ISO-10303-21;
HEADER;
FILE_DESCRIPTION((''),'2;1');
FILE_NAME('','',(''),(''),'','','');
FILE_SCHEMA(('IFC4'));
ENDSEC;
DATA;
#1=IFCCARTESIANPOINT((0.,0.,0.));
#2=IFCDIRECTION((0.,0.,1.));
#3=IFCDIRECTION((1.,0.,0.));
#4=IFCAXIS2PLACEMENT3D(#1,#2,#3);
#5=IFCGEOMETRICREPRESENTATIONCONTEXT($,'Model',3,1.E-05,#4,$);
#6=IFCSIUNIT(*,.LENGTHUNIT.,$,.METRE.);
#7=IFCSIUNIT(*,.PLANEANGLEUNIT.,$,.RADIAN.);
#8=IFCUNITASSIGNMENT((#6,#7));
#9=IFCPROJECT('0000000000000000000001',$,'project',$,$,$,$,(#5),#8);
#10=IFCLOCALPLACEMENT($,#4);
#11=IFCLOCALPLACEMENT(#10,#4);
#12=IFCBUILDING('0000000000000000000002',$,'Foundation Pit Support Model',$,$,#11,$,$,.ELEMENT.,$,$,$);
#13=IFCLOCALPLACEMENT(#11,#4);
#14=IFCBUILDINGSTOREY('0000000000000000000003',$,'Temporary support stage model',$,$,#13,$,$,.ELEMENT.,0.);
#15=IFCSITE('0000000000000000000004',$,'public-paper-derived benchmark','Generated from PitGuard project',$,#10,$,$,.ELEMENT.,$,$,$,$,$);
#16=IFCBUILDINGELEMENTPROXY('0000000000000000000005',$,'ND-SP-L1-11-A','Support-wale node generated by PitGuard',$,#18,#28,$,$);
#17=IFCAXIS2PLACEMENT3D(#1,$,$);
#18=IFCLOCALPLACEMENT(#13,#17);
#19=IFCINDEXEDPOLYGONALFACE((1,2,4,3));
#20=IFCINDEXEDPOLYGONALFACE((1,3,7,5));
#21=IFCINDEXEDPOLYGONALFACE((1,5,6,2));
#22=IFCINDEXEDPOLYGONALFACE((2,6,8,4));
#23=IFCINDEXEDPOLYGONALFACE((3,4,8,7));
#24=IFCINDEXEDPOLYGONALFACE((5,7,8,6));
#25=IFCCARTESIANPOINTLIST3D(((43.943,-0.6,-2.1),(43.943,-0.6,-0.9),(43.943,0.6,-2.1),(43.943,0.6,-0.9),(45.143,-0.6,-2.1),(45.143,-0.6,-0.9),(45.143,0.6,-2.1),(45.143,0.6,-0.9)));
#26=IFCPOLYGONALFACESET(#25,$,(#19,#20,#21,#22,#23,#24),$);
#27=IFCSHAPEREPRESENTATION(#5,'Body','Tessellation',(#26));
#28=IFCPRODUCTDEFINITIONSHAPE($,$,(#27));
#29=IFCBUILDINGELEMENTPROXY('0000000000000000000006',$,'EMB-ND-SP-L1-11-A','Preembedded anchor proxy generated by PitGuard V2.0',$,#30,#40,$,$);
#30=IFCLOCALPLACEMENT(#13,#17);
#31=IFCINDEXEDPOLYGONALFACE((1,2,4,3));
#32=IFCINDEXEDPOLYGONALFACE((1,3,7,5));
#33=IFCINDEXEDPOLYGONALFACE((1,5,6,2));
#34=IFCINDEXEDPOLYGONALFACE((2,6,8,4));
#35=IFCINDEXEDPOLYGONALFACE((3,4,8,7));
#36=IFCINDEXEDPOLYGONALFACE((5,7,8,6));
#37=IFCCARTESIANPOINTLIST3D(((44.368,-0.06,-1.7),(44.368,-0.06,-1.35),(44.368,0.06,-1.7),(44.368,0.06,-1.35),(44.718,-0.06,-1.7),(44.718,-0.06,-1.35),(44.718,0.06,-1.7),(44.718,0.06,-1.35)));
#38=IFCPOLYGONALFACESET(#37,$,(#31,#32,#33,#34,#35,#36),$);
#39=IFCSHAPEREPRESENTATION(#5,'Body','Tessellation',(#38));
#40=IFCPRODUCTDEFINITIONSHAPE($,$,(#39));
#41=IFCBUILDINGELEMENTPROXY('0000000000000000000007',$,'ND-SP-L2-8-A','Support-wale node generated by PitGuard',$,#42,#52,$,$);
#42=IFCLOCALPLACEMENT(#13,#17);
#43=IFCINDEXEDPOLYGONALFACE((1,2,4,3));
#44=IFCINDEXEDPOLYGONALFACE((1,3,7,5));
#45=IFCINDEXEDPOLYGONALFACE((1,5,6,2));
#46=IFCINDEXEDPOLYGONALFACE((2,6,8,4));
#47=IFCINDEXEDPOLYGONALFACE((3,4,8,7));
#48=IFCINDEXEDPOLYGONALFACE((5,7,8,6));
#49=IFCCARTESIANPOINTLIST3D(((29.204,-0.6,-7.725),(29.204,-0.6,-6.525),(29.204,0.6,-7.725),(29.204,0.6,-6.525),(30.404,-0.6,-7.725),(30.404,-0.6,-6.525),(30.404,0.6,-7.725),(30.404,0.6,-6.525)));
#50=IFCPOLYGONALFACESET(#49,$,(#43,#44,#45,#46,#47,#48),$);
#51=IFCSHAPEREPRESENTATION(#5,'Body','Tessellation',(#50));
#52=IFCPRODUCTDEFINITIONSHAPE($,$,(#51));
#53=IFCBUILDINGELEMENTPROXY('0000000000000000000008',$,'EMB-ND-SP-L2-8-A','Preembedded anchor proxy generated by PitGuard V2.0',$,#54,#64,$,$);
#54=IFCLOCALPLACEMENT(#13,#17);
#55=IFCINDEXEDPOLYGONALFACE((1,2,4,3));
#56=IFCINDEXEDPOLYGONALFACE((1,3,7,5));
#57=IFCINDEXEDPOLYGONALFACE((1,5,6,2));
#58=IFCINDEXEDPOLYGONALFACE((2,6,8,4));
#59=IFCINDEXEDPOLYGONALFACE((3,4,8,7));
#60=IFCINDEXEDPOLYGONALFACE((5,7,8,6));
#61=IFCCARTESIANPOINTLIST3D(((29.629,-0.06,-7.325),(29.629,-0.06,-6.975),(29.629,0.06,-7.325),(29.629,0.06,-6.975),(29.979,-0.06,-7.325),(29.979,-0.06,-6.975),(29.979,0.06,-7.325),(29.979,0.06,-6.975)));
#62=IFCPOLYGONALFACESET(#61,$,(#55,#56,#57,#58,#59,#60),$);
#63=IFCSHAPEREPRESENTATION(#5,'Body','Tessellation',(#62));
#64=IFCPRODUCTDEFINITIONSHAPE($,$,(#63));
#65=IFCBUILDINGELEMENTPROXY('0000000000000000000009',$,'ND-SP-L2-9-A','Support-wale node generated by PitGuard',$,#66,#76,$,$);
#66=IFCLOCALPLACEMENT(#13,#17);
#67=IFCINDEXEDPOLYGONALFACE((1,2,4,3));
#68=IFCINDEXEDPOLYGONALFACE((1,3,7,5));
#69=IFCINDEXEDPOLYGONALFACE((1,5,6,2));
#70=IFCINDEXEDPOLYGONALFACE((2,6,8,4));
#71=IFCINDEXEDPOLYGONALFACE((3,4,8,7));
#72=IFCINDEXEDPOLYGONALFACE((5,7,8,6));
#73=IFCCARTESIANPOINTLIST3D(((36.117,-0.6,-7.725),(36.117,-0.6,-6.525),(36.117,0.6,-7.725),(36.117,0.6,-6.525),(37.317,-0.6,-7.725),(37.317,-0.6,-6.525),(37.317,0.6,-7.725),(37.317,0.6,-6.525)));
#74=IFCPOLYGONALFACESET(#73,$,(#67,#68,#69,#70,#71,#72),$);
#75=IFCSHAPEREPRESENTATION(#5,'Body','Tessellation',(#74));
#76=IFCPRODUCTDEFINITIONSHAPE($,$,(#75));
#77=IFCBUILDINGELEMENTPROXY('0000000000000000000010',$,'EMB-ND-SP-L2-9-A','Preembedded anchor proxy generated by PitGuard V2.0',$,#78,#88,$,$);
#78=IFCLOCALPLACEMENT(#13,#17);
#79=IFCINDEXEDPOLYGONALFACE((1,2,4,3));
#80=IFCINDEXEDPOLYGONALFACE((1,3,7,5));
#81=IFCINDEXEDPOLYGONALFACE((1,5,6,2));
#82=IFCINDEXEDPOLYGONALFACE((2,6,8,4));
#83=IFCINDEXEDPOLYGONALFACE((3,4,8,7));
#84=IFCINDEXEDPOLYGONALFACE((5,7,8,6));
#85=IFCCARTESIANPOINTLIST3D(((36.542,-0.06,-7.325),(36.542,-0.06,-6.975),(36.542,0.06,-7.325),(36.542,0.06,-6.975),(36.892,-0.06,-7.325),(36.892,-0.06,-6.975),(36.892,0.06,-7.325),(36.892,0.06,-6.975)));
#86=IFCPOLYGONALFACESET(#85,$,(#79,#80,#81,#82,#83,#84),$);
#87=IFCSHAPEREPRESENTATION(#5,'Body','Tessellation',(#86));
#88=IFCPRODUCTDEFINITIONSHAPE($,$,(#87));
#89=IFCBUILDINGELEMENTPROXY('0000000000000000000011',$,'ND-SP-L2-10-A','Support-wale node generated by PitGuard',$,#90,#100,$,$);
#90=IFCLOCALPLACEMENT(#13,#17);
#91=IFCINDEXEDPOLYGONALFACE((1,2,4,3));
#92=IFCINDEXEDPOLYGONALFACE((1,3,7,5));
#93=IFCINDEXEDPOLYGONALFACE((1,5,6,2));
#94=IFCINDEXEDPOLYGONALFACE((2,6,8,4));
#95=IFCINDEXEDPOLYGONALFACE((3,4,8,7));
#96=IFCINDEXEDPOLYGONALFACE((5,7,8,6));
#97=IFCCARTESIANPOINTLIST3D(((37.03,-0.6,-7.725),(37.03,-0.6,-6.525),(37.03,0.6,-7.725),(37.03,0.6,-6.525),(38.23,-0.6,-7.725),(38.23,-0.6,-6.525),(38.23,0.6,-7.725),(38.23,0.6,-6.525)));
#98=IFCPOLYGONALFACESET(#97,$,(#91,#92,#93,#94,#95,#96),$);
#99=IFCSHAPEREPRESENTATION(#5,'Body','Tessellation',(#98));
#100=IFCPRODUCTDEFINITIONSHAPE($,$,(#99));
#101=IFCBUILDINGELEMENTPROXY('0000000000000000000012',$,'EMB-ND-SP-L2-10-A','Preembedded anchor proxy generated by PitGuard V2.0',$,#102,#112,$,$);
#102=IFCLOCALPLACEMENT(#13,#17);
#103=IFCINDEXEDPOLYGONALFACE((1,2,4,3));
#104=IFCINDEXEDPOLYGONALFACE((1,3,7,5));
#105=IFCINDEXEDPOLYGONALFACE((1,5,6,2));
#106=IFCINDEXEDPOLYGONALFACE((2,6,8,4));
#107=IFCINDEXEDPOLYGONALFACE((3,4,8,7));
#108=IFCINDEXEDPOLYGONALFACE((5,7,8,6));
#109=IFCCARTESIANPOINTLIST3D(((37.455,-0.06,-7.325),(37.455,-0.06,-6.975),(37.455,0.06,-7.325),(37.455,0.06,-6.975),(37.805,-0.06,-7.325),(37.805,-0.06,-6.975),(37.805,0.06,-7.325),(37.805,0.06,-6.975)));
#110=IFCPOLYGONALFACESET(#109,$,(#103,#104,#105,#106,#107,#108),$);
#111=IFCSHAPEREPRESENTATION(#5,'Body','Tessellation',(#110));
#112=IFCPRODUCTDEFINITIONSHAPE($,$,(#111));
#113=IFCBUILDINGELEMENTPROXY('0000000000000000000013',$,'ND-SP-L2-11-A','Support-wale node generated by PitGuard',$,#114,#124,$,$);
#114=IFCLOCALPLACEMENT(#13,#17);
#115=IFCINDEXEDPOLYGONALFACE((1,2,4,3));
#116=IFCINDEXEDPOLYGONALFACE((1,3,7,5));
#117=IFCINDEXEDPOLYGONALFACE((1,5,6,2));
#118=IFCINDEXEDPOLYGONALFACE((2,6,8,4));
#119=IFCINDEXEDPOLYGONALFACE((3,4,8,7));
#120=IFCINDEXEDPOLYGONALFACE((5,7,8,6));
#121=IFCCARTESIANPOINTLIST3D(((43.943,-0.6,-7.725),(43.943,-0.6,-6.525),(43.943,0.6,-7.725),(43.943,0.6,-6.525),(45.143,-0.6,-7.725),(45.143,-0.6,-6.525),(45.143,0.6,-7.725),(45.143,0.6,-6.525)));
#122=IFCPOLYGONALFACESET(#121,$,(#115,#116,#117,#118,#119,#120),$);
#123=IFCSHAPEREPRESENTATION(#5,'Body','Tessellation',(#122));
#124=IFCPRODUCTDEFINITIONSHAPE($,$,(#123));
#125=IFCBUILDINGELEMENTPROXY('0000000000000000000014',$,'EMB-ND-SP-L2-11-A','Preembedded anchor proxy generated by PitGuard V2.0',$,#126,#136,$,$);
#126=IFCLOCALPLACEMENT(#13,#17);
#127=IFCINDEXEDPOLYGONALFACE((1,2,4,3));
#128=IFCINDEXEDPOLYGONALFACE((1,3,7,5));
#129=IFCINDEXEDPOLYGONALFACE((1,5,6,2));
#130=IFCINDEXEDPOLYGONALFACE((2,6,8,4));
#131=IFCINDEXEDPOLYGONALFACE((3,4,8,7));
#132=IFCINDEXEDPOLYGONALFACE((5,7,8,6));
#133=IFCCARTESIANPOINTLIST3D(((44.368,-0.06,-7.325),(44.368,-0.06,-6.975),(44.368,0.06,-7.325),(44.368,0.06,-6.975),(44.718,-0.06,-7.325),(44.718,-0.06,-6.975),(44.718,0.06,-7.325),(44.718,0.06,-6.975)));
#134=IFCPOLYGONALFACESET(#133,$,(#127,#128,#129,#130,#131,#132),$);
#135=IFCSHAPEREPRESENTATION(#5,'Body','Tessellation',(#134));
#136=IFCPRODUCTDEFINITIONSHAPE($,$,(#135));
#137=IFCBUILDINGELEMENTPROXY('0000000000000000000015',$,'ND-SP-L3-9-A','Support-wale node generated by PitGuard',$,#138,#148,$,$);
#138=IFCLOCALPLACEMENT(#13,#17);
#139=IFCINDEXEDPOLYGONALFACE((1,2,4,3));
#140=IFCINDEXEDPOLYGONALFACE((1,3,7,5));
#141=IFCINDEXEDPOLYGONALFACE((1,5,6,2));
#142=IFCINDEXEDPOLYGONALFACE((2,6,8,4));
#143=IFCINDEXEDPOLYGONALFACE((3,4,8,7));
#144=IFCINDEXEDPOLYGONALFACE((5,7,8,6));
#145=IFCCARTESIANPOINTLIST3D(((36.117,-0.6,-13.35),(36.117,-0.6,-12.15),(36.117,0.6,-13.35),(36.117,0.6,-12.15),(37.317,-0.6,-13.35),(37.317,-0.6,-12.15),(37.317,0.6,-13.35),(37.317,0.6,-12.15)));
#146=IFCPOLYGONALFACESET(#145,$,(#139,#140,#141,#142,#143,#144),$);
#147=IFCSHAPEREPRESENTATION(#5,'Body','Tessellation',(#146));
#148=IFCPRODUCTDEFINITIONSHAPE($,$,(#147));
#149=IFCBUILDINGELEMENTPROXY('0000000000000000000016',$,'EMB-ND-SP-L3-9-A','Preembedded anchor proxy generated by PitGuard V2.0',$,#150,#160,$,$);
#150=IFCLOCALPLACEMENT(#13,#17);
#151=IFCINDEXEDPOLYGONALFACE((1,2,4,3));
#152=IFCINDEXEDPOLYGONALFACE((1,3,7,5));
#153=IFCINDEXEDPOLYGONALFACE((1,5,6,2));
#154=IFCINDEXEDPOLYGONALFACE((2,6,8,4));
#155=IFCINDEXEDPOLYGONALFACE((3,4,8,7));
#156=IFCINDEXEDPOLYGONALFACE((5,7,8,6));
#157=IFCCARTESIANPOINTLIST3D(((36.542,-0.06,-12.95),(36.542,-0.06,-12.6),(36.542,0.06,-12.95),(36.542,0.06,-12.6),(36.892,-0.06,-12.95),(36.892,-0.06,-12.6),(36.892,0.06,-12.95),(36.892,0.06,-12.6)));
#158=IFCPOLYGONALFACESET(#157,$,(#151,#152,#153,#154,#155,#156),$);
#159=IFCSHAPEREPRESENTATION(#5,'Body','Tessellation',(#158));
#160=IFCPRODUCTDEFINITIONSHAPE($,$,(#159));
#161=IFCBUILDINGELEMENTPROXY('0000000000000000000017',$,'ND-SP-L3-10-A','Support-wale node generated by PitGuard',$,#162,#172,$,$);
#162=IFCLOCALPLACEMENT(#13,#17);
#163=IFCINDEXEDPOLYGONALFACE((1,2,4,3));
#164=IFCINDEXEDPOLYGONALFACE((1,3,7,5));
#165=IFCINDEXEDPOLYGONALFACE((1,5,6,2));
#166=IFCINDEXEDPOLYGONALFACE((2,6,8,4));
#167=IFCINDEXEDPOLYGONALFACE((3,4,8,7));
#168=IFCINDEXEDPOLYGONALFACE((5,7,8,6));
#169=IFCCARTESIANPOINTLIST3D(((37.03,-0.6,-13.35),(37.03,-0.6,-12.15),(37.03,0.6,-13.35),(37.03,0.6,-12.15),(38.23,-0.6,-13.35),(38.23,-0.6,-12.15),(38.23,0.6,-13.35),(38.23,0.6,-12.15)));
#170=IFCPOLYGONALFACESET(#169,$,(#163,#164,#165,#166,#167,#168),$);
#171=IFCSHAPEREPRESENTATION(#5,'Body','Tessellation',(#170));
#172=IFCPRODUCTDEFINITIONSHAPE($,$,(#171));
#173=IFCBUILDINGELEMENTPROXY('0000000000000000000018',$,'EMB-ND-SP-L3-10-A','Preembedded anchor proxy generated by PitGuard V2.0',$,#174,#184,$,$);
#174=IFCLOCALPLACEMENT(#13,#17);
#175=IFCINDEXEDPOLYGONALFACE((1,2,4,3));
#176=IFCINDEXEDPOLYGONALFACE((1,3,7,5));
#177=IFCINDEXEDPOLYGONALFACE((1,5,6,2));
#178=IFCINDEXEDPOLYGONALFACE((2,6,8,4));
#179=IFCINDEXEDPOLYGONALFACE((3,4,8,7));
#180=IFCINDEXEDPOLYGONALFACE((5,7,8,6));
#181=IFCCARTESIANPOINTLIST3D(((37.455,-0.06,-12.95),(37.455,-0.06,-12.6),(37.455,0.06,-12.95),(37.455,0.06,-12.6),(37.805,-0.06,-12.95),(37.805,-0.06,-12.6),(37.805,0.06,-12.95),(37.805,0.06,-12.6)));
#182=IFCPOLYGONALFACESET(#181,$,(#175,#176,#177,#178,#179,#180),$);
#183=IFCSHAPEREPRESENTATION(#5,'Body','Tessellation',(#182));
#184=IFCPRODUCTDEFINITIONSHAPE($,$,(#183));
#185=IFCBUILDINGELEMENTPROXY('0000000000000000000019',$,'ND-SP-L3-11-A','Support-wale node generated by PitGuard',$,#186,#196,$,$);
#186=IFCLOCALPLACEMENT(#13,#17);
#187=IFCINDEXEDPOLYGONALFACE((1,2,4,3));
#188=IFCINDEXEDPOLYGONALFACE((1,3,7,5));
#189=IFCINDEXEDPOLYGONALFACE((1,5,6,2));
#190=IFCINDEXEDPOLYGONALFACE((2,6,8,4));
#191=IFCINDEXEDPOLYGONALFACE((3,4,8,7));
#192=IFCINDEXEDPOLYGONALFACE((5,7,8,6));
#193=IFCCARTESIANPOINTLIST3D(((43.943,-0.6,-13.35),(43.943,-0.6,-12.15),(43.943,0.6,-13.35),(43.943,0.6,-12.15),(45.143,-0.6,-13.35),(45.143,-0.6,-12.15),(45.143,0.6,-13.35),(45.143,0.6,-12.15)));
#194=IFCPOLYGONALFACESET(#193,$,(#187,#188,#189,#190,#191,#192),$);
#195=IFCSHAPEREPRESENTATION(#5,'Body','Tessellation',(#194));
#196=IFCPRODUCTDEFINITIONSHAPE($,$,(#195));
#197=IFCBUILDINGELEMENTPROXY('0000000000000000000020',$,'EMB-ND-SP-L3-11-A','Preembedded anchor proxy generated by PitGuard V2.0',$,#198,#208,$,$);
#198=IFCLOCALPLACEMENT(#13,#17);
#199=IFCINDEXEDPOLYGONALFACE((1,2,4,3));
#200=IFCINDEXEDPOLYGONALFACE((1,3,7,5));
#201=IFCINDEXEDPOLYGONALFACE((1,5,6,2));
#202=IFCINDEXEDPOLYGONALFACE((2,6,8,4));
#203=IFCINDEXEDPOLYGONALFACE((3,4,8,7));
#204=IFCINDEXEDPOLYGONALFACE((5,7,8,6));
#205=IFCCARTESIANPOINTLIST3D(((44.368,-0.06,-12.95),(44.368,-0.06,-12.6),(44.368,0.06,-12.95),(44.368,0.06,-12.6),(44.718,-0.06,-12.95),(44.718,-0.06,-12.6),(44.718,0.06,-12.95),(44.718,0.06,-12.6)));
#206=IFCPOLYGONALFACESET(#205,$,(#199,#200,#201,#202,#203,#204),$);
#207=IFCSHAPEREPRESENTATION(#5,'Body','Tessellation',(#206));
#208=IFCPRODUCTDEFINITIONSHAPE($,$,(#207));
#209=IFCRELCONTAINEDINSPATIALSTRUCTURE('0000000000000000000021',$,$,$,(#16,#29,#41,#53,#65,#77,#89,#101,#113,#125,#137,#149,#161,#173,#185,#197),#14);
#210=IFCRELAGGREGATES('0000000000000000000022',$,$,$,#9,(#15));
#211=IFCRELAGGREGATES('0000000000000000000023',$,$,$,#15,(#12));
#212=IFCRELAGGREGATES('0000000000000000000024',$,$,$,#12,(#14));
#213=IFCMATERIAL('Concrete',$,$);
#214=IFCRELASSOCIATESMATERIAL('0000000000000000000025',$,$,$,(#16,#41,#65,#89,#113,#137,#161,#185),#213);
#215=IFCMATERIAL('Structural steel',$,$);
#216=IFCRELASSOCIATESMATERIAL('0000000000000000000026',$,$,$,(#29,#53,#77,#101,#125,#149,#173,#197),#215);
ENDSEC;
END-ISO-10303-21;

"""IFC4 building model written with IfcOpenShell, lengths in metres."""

from ifc_helpers import new_model, si_unit, frame, origin_with_axes, origin_2d, place, context, project, spatial, rectangle, extrude, material, element, save


model = new_model("IFC4")

# Units and contexts
model_context = context("Model", 3, precision=1e-05, world=origin_with_axes())
ifc_project = project(units=[si_unit("LENGTHUNIT", "METRE"), si_unit("PLANEANGLEUNIT", "RADIAN")], contexts=[model_context])

# Site, building, storey
site_placement = place(None, origin_with_axes())
site = spatial("IfcSite", under=ifc_project, at=site_placement, Name="public-paper-derived benchmark", Description="Generated from PitGuard project", CompositionType="ELEMENT")
building_placement = place(site_placement, origin_with_axes())
building = spatial("IfcBuilding", under=site, at=building_placement, Name="Foundation Pit Support Model", CompositionType="ELEMENT")
storey_placement = place(building_placement, origin_with_axes())
storey = spatial("IfcBuildingStorey", under=building, at=storey_placement, Name="Temporary support stage model", CompositionType="ELEMENT", Elevation=0.0)

# Shared definitions
ifc_material_1 = material(Name="Concrete")

# Shared definitions
ifc_material_2 = material(Name="Structural steel")

# Building element proxies
proxy_1_placement = place(storey_placement, frame((44.543, 0.0, -2.1), z_axis=(0.0, 0.0, 1.0), x_axis=(1.0, 0.0, 0.0)))
element("IfcBuildingElementProxy", 1, at=proxy_1_placement, inside=storey, material=ifc_material_1, Name="ND-SP-L1-11-A", Description="Support-wale node generated by PitGuard", context=model_context, shape_type="SweptSolid", body=[
    extrude(rectangle(XDim=1.2, YDim=1.2, at=origin_2d()), origin_with_axes(), (0.0, 0.0, 1.0), 1.2),
])
proxy_2_placement = place(storey_placement, frame((44.543, 0.0, -1.7), z_axis=(0.0, 0.0, 1.0), x_axis=(1.0, 0.0, 0.0)))
element("IfcBuildingElementProxy", 2, at=proxy_2_placement, inside=storey, material=ifc_material_2, Name="EMB-ND-SP-L1-11-A", Description="Preembedded anchor proxy generated by PitGuard V2.0", context=model_context, shape_type="SweptSolid", body=[
    extrude(rectangle(XDim=0.35, YDim=0.12, at=origin_2d()), origin_with_axes(), (0.0, 0.0, 1.0), 0.35),
])
proxy_3_placement = place(storey_placement, frame((29.804, 0.0, -7.725), z_axis=(0.0, 0.0, 1.0), x_axis=(1.0, 0.0, 0.0)))
element("IfcBuildingElementProxy", 3, at=proxy_3_placement, inside=storey, material=ifc_material_1, Name="ND-SP-L2-8-A", Description="Support-wale node generated by PitGuard", context=model_context, shape_type="SweptSolid", body=[
    extrude(rectangle(XDim=1.2, YDim=1.2, at=origin_2d()), origin_with_axes(), (0.0, 0.0, 1.0), 1.2),
])
proxy_4_placement = place(storey_placement, frame((29.804, 0.0, -7.325), z_axis=(0.0, 0.0, 1.0), x_axis=(1.0, 0.0, 0.0)))
element("IfcBuildingElementProxy", 4, at=proxy_4_placement, inside=storey, material=ifc_material_2, Name="EMB-ND-SP-L2-8-A", Description="Preembedded anchor proxy generated by PitGuard V2.0", context=model_context, shape_type="SweptSolid", body=[
    extrude(rectangle(XDim=0.35, YDim=0.12, at=origin_2d()), origin_with_axes(), (0.0, 0.0, 1.0), 0.35),
])
proxy_5_placement = place(storey_placement, frame((36.717, 0.0, -7.725), z_axis=(0.0, 0.0, 1.0), x_axis=(1.0, 0.0, 0.0)))
element("IfcBuildingElementProxy", 5, at=proxy_5_placement, inside=storey, material=ifc_material_1, Name="ND-SP-L2-9-A", Description="Support-wale node generated by PitGuard", context=model_context, shape_type="SweptSolid", body=[
    extrude(rectangle(XDim=1.2, YDim=1.2, at=origin_2d()), origin_with_axes(), (0.0, 0.0, 1.0), 1.2),
])
proxy_6_placement = place(storey_placement, frame((36.717, 0.0, -7.325), z_axis=(0.0, 0.0, 1.0), x_axis=(1.0, 0.0, 0.0)))
element("IfcBuildingElementProxy", 6, at=proxy_6_placement, inside=storey, material=ifc_material_2, Name="EMB-ND-SP-L2-9-A", Description="Preembedded anchor proxy generated by PitGuard V2.0", context=model_context, shape_type="SweptSolid", body=[
    extrude(rectangle(XDim=0.35, YDim=0.12, at=origin_2d()), origin_with_axes(), (0.0, 0.0, 1.0), 0.35),
])
proxy_7_placement = place(storey_placement, frame((37.63, 0.0, -7.725), z_axis=(0.0, 0.0, 1.0), x_axis=(1.0, 0.0, 0.0)))
element("IfcBuildingElementProxy", 7, at=proxy_7_placement, inside=storey, material=ifc_material_1, Name="ND-SP-L2-10-A", Description="Support-wale node generated by PitGuard", context=model_context, shape_type="SweptSolid", body=[
    extrude(rectangle(XDim=1.2, YDim=1.2, at=origin_2d()), origin_with_axes(), (0.0, 0.0, 1.0), 1.2),
])
proxy_8_placement = place(storey_placement, frame((37.63, 0.0, -7.325), z_axis=(0.0, 0.0, 1.0), x_axis=(1.0, 0.0, 0.0)))
element("IfcBuildingElementProxy", 8, at=proxy_8_placement, inside=storey, material=ifc_material_2, Name="EMB-ND-SP-L2-10-A", Description="Preembedded anchor proxy generated by PitGuard V2.0", context=model_context, shape_type="SweptSolid", body=[
    extrude(rectangle(XDim=0.35, YDim=0.12, at=origin_2d()), origin_with_axes(), (0.0, 0.0, 1.0), 0.35),
])
proxy_9_placement = place(storey_placement, frame((44.543, 0.0, -7.725), z_axis=(0.0, 0.0, 1.0), x_axis=(1.0, 0.0, 0.0)))
element("IfcBuildingElementProxy", 9, at=proxy_9_placement, inside=storey, material=ifc_material_1, Name="ND-SP-L2-11-A", Description="Support-wale node generated by PitGuard", context=model_context, shape_type="SweptSolid", body=[
    extrude(rectangle(XDim=1.2, YDim=1.2, at=origin_2d()), origin_with_axes(), (0.0, 0.0, 1.0), 1.2),
])
proxy_10_placement = place(storey_placement, frame((44.543, 0.0, -7.325), z_axis=(0.0, 0.0, 1.0), x_axis=(1.0, 0.0, 0.0)))
element("IfcBuildingElementProxy", 10, at=proxy_10_placement, inside=storey, material=ifc_material_2, Name="EMB-ND-SP-L2-11-A", Description="Preembedded anchor proxy generated by PitGuard V2.0", context=model_context, shape_type="SweptSolid", body=[
    extrude(rectangle(XDim=0.35, YDim=0.12, at=origin_2d()), origin_with_axes(), (0.0, 0.0, 1.0), 0.35),
])
proxy_11_placement = place(storey_placement, frame((36.717, 0.0, -13.35), z_axis=(0.0, 0.0, 1.0), x_axis=(1.0, 0.0, 0.0)))
element("IfcBuildingElementProxy", 11, at=proxy_11_placement, inside=storey, material=ifc_material_1, Name="ND-SP-L3-9-A", Description="Support-wale node generated by PitGuard", context=model_context, shape_type="SweptSolid", body=[
    extrude(rectangle(XDim=1.2, YDim=1.2, at=origin_2d()), origin_with_axes(), (0.0, 0.0, 1.0), 1.2),
])
proxy_12_placement = place(storey_placement, frame((36.717, 0.0, -12.95), z_axis=(0.0, 0.0, 1.0), x_axis=(1.0, 0.0, 0.0)))
element("IfcBuildingElementProxy", 12, at=proxy_12_placement, inside=storey, material=ifc_material_2, Name="EMB-ND-SP-L3-9-A", Description="Preembedded anchor proxy generated by PitGuard V2.0", context=model_context, shape_type="SweptSolid", body=[
    extrude(rectangle(XDim=0.35, YDim=0.12, at=origin_2d()), origin_with_axes(), (0.0, 0.0, 1.0), 0.35),
])
proxy_13_placement = place(storey_placement, frame((37.63, 0.0, -13.35), z_axis=(0.0, 0.0, 1.0), x_axis=(1.0, 0.0, 0.0)))
element("IfcBuildingElementProxy", 13, at=proxy_13_placement, inside=storey, material=ifc_material_1, Name="ND-SP-L3-10-A", Description="Support-wale node generated by PitGuard", context=model_context, shape_type="SweptSolid", body=[
    extrude(rectangle(XDim=1.2, YDim=1.2, at=origin_2d()), origin_with_axes(), (0.0, 0.0, 1.0), 1.2),
])
proxy_14_placement = place(storey_placement, frame((37.63, 0.0, -12.95), z_axis=(0.0, 0.0, 1.0), x_axis=(1.0, 0.0, 0.0)))
element("IfcBuildingElementProxy", 14, at=proxy_14_placement, inside=storey, material=ifc_material_2, Name="EMB-ND-SP-L3-10-A", Description="Preembedded anchor proxy generated by PitGuard V2.0", context=model_context, shape_type="SweptSolid", body=[
    extrude(rectangle(XDim=0.35, YDim=0.12, at=origin_2d()), origin_with_axes(), (0.0, 0.0, 1.0), 0.35),
])
proxy_15_placement = place(storey_placement, frame((44.543, 0.0, -13.35), z_axis=(0.0, 0.0, 1.0), x_axis=(1.0, 0.0, 0.0)))
element("IfcBuildingElementProxy", 15, at=proxy_15_placement, inside=storey, material=ifc_material_1, Name="ND-SP-L3-11-A", Description="Support-wale node generated by PitGuard", context=model_context, shape_type="SweptSolid", body=[
    extrude(rectangle(XDim=1.2, YDim=1.2, at=origin_2d()), origin_with_axes(), (0.0, 0.0, 1.0), 1.2),
])
proxy_16_placement = place(storey_placement, frame((44.543, 0.0, -12.95), z_axis=(0.0, 0.0, 1.0), x_axis=(1.0, 0.0, 0.0)))
element("IfcBuildingElementProxy", 16, at=proxy_16_placement, inside=storey, material=ifc_material_2, Name="EMB-ND-SP-L3-11-A", Description="Preembedded anchor proxy generated by PitGuard V2.0", context=model_context, shape_type="SweptSolid", body=[
    extrude(rectangle(XDim=0.35, YDim=0.12, at=origin_2d()), origin_with_axes(), (0.0, 0.0, 1.0), 0.35),
])

save(model, "model.ifc")
